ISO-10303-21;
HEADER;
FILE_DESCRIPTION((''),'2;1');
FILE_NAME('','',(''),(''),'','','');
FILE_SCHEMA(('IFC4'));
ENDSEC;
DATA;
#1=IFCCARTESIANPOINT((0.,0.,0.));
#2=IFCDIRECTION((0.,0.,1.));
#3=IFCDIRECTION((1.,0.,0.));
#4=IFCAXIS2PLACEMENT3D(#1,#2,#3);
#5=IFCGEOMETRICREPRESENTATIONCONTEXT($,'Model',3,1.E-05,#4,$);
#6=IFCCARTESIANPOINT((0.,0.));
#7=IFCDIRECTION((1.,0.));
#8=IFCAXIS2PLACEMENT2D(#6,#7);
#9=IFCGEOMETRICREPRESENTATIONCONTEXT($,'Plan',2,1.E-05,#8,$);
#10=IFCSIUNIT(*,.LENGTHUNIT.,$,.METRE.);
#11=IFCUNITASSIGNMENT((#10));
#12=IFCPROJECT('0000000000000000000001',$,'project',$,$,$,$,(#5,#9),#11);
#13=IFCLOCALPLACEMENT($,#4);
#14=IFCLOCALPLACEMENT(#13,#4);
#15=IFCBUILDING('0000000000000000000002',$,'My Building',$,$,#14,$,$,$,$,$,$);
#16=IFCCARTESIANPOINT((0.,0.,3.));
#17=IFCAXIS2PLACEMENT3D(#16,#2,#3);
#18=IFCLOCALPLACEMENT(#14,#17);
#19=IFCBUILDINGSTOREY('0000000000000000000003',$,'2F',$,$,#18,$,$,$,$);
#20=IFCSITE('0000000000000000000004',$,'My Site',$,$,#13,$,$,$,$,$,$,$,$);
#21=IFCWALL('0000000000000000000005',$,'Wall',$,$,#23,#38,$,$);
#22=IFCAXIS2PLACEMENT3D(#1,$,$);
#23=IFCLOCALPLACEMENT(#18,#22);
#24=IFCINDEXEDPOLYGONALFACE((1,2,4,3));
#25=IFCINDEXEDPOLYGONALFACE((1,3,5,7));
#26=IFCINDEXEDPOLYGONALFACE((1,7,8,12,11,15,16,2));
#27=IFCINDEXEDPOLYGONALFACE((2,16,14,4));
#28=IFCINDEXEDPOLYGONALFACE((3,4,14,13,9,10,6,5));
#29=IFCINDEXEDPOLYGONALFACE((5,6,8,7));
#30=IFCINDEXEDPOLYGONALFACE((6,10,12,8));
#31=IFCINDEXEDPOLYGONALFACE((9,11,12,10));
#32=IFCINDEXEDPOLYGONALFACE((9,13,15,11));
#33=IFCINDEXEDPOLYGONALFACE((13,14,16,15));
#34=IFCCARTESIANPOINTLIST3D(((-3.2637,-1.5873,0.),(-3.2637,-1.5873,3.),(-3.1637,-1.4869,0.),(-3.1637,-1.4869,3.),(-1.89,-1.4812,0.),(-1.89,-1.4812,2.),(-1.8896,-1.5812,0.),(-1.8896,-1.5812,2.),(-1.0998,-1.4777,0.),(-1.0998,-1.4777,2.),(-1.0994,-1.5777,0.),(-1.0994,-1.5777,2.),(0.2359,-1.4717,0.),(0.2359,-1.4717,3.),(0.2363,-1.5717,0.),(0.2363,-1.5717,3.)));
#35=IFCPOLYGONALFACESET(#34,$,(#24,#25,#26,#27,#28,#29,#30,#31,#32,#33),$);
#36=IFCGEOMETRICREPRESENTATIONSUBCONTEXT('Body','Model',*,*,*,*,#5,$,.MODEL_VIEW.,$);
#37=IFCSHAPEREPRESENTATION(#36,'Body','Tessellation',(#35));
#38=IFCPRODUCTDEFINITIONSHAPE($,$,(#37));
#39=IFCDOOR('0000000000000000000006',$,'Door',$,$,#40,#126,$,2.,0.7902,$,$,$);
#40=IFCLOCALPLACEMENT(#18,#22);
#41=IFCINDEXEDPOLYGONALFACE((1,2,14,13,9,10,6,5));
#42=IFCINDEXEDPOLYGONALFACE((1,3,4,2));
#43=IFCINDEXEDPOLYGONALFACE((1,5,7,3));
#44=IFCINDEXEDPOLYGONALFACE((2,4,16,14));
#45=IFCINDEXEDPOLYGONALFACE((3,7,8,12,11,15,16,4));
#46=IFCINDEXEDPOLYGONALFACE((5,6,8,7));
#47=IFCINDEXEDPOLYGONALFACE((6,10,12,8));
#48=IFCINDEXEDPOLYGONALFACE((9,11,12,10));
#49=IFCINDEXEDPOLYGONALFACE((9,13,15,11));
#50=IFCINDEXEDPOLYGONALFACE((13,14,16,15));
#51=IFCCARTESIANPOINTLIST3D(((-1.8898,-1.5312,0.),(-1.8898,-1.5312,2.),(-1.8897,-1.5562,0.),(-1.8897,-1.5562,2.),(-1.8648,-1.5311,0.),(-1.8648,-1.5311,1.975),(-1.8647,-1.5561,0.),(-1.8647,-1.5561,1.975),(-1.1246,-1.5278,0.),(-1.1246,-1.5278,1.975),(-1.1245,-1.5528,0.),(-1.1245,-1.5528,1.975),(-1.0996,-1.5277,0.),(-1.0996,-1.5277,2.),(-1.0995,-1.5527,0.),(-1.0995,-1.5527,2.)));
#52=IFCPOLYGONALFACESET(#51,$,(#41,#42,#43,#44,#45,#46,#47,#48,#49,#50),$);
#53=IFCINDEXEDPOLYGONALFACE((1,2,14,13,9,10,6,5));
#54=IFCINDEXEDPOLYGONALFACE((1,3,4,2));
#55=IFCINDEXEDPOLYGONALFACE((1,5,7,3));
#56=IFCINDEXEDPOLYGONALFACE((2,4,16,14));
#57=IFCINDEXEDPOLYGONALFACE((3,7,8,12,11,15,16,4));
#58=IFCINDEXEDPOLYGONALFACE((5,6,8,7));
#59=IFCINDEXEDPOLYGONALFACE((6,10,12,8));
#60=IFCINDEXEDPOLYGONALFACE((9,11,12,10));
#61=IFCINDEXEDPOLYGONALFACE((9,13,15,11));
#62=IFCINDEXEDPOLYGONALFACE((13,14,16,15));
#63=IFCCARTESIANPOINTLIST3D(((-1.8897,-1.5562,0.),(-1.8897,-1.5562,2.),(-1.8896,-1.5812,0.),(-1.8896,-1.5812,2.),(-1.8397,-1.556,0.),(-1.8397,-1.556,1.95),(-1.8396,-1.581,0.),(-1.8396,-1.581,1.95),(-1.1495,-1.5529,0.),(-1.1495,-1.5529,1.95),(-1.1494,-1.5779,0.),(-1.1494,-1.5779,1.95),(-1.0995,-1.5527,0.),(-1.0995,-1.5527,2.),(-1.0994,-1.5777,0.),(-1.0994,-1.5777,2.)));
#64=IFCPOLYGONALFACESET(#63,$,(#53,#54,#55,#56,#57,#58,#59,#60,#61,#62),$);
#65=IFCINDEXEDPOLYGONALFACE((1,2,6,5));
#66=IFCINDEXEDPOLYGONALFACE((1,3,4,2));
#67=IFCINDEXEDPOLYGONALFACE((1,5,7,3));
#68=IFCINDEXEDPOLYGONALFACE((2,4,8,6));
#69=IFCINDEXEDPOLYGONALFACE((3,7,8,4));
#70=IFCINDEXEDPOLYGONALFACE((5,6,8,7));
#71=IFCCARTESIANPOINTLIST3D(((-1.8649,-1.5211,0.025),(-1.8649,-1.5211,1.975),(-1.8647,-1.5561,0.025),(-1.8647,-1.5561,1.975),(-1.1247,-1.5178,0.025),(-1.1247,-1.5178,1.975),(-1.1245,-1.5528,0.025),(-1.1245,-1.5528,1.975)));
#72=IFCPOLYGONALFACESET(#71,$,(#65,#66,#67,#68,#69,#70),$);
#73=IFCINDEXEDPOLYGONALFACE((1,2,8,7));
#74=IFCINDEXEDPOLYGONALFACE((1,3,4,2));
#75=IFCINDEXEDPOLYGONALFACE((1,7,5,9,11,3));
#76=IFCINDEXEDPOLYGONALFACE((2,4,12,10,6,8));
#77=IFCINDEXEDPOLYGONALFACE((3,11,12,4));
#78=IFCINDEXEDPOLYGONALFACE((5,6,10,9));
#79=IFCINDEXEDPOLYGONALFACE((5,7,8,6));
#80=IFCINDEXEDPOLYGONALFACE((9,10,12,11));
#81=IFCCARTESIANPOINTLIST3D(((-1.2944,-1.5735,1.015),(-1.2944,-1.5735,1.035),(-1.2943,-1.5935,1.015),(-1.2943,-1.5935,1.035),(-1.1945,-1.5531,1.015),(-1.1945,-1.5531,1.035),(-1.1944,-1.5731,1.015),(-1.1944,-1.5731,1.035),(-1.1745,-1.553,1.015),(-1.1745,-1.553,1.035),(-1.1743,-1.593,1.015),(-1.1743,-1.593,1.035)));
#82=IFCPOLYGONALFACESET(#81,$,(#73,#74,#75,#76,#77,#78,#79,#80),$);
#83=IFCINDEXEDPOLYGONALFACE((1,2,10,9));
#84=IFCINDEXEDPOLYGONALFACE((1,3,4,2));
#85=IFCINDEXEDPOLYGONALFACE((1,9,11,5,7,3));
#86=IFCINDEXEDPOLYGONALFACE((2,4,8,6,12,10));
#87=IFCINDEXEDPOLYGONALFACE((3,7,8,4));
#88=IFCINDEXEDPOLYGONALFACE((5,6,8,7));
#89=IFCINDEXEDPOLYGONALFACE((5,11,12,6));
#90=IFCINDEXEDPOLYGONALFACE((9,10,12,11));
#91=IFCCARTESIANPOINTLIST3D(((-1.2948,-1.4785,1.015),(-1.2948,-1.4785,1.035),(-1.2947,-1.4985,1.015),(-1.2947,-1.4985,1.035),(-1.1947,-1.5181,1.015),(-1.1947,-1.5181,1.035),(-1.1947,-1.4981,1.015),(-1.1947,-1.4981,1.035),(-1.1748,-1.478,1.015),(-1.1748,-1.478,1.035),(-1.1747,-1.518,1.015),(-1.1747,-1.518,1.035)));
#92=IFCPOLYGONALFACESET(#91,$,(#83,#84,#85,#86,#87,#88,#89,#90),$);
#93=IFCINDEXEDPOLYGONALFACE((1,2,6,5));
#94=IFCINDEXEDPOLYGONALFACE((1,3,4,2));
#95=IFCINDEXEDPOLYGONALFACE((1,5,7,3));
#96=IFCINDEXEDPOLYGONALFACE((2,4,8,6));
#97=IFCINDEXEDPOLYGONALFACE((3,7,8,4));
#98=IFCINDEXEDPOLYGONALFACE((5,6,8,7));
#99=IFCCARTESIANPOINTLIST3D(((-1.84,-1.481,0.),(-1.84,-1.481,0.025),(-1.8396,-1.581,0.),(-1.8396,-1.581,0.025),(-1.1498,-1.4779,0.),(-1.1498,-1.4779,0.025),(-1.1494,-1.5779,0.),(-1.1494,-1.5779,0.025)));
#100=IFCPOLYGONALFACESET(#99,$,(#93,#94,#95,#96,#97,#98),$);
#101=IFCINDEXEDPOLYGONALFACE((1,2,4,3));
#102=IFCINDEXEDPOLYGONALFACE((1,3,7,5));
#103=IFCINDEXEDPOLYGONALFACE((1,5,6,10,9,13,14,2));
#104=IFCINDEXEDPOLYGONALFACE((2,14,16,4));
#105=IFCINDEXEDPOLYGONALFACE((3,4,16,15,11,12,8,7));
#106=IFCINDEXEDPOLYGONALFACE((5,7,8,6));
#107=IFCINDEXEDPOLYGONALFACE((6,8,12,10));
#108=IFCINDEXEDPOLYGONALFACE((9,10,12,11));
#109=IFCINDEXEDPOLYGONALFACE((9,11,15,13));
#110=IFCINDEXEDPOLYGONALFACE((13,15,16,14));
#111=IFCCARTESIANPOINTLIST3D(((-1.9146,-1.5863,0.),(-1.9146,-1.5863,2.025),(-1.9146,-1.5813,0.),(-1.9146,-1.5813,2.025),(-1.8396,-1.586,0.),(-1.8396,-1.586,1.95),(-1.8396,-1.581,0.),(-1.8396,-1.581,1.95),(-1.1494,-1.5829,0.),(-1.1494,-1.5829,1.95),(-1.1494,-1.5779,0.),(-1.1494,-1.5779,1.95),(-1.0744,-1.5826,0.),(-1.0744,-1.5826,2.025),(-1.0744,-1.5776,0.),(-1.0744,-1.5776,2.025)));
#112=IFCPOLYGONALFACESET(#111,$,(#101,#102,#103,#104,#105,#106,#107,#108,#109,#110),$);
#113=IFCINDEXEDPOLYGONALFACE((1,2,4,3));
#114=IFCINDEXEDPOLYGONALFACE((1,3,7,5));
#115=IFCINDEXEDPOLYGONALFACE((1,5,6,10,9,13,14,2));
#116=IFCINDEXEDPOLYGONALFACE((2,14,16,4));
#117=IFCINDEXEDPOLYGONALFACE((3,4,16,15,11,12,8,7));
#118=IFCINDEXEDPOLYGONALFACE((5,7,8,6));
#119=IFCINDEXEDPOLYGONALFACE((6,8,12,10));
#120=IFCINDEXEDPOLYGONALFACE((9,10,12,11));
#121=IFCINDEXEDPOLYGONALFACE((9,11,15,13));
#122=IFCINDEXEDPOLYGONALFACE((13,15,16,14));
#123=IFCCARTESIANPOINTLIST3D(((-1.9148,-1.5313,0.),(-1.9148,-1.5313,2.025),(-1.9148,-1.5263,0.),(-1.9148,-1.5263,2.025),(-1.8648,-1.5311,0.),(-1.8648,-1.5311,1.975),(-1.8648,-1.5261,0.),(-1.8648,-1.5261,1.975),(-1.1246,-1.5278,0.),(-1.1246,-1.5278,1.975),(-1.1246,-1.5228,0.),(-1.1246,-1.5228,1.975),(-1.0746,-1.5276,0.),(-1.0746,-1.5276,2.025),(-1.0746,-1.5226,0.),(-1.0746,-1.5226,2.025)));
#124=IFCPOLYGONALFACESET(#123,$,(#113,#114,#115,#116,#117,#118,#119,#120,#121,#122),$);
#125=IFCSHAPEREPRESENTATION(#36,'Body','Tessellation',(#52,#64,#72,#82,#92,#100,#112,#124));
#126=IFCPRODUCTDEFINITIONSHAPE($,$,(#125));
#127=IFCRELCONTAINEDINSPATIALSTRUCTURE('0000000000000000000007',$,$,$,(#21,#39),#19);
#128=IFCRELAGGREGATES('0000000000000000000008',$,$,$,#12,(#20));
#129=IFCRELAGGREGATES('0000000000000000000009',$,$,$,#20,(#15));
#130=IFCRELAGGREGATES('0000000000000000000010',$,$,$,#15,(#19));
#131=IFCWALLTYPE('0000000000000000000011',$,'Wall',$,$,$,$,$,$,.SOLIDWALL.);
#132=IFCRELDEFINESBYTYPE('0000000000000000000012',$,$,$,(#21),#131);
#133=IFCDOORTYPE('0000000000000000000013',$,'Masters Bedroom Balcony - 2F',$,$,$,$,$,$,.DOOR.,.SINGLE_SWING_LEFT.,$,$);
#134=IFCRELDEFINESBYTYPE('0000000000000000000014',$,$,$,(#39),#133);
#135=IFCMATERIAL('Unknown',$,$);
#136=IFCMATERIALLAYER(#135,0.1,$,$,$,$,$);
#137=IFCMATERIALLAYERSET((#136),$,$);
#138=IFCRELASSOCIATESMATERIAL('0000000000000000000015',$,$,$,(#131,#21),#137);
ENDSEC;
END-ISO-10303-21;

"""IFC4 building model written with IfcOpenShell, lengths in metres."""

from ifc_helpers import new_model, entity, si_unit, frame, origin_with_axes, origin_2d_with_axis, place, context, subcontext, project, spatial, line, indexed_curve, outline, extrude, shape, source, transform, mapped, material, layer, layer_set, layer_usage, type_object, type_shapes, element, fill, save


model = new_model("IFC4")

# Units and contexts
model_context = context("Model", 3, precision=1e-05, world=origin_with_axes())
plan_context = context("Plan", 2, precision=1e-05, world=origin_2d_with_axis())
body_context_1 = subcontext(model_context, "Body", "Model", "MODEL_VIEW")
body_context_2 = subcontext(plan_context, "Body", "Plan", "PLAN_VIEW")
ifc_project = project(units=[si_unit("LENGTHUNIT", "METRE")], contexts=[model_context, plan_context])

# Site, building, storey
site_placement = place(None, origin_with_axes())
site = spatial("IfcSite", under=ifc_project, at=site_placement, Name="My Site")
building_placement = place(site_placement, origin_with_axes())
building = spatial("IfcBuilding", under=site, at=building_placement, Name="My Building")
storey_placement = place(building_placement, frame((0.0, 0.0, 3.0), z_axis=(0.0, 0.0, 1.0), x_axis=(1.0, 0.0, 0.0)))
storey = spatial("IfcBuildingStorey", under=building, at=storey_placement, Name="2F")

# Shared definitions
ifc_material = material(Name="Unknown")

# Shared definitions
ifc_layer_1 = layer(ifc_material, 0.1)
ifc_layer_set_1 = layer_set([ifc_layer_1])
wall_type = type_object("IfcWallType", Name="Wall", PredefinedType="SOLIDWALL", material=ifc_layer_set_1)

# Wall, opening, door
ifc_layer_usage_1 = layer_usage(ifc_layer_set_1, "AXIS2", "POSITIVE", 0.0)
wall_1_placement = place(storey_placement, frame((-3.2637, -1.5873, 0.0), z_axis=(0.0, 0.0, 1.0), x_axis=(0.99999, 0.004461, 0.0)))
wall_1 = element("IfcWall", 1, at=wall_1_placement, inside=storey, type_object=wall_type, material=ifc_layer_usage_1, Name="Wall", context=body_context_1, shape_type="SweptSolid", body=[
    extrude(outline(indexed_curve([(0.0, 0.0), (0.1004, 0.1), (3.5, 0.1), (3.5, 0.0)], segments=[line(1, 2, 3, 4, 1)])), origin_with_axes(), (0.0, 0.0, 1.0), 3.0),
])
shared_shape_1 = source(origin_with_axes(), body_context_1, "Body", "SweptSolid", [
    extrude(outline(indexed_curve([(0.0, 0.0), (0.7902, 0.0), (0.7902, 2.0), (0.0, 2.0)], segments=[line(1, 2, 3, 4, 1)])), frame((0.0, -0.6, 0.0), z_axis=(0.0, -1.0, 0.0), x_axis=(1.0, 0.0, 0.0)), (0.0, 0.0, -1.0), 1.2),
])
opening_1_placement = place(wall_1_placement, frame((1.3741, 0.0, 0.0), z_axis=(0.0, 0.0, 1.0), x_axis=(1.0, 0.0, 0.0)))
opening_1 = element("IfcOpeningElement", 2, at=opening_1_placement, cuts=wall_1, PredefinedType="OPENING", context=body_context_1, shape_type="MappedRepresentation", body=[
    mapped(shared_shape_1, transform((0.0, 0.0, 0.0), x_axis=(1.0, 0.0, 0.0), y_axis=(0.0, 1.0, 0.0), z_axis=(0.0, 0.0, 1.0), scale=1.0)),
])
door_type_1 = type_object("IfcDoorType", Name="Masters Bedroom Balcony - 2F", OperationType="SINGLE_SWING_LEFT", PredefinedType="DOOR")
shared_shape_2 = source(origin_with_axes(), body_context_1, "Body", "SweptSolid", [
    extrude(outline(indexed_curve([(0.0, 0.0), (0.0, 2.0), (0.7902, 2.0), (0.7902, 0.0), (0.7652, 0.0), (0.7652, 1.975), (0.025, 1.975), (0.025, 0.0)], segments=[line(1, 2, 3, 4, 5, 6, 7, 8, 1)])), frame((0.0, 0.025, 0.0), z_axis=(0.0, -1.0, 0.0), x_axis=(1.0, 0.0, 0.0)), (0.0, 0.0, -1.0), 0.025),
    extrude(outline(indexed_curve([(0.0, 0.0), (0.0, 2.0), (0.7902, 2.0), (0.7902, 0.0), (0.7402, 0.0), (0.7402, 1.95), (0.05, 1.95), (0.05, 0.0)], segments=[line(1, 2, 3, 4, 5, 6, 7, 8, 1)])), frame((0.0, 0.0, 0.0), z_axis=(0.0, -1.0, 0.0), x_axis=(1.0, 0.0, 0.0)), (0.0, 0.0, -1.0), 0.025),
    extrude(outline(indexed_curve([(0.0, 0.0), (0.7402, 0.0), (0.7402, 0.035), (0.0, 0.035)], segments=[line(1, 2, 3, 4, 1)])), frame((0.025, 0.025, 0.025), z_axis=(0.0, 0.0, 1.0), x_axis=(1.0, 0.0, 0.0)), (0.0, 0.0, 1.0), 1.95),
    extrude(outline(indexed_curve([(0.0, 0.0), (0.0, -0.04), (-0.12, -0.04), (-0.12, -0.02), (-0.02, -0.02), (-0.02, 0.0)], segments=[line(1, 2, 3, 4, 5, 6, 1)])), frame((0.7152, 0.025, 1.015), z_axis=(0.0, 0.0, 1.0), x_axis=(1.0, 0.0, 0.0)), (0.0, 0.0, 1.0), 0.02),
    extrude(outline(indexed_curve([(0.0, 0.0), (0.0, 0.04), (-0.12, 0.04), (-0.12, 0.02), (-0.02, 0.02), (-0.02, 0.0)], segments=[line(1, 2, 3, 4, 5, 6, 1)])), frame((0.7152, 0.06, 1.015), z_axis=(0.0, 0.0, 1.0), x_axis=(1.0, 0.0, 0.0)), (0.0, 0.0, 1.0), 0.02),
    extrude(outline(indexed_curve([(0.0, 0.0), (0.6902, 0.0), (0.6902, 0.1), (0.0, 0.1)], segments=[line(1, 2, 3, 4, 1)])), frame((0.05, 0.0, 0.0), z_axis=(0.0, 0.0, 1.0), x_axis=(1.0, 0.0, 0.0)), (0.0, 0.0, 1.0), 0.025),
    extrude(outline(indexed_curve([(0.0, 0.0), (0.0, 2.025), (0.8402, 2.025), (0.8402, 0.0), (0.7652, 0.0), (0.7652, 1.95), (0.075, 1.95), (0.075, 0.0)], segments=[line(1, 2, 3, 4, 5, 6, 7, 8, 1)])), frame((-0.025, -0.005, 0.0), z_axis=(0.0, -1.0, 0.0), x_axis=(1.0, 0.0, 0.0)), (0.0, 0.0, -1.0), 0.005),
    extrude(outline(indexed_curve([(0.0, 0.0), (0.0, 2.025), (0.8402, 2.025), (0.8402, 0.0), (0.7902, 0.0), (0.7902, 1.975), (0.05, 1.975), (0.05, 0.0)], segments=[line(1, 2, 3, 4, 5, 6, 7, 8, 1)])), frame((-0.025, 0.05, 0.0), z_axis=(0.0, -1.0, 0.0), x_axis=(1.0, 0.0, 0.0)), (0.0, 0.0, -1.0), 0.005),
])
shared_shape_3 = source(origin_with_axes(), body_context_2, "Body", "Curve2D", [
    entity("IfcIndexedPolyCurve", entity("IfcCartesianPointList2D", [[0.0, 0.0], [0.0, 0.05], [0.025, 0.05], [0.025, 0.025], [0.05, 0.025], [0.05, 0.0]]), [entity("IfcLineIndex", [1, 2, 3, 4, 5, 6, 1])]),
    entity("IfcIndexedPolyCurve", entity("IfcCartesianPointList2D", [[0.7902, 0.0], [0.7902, 0.05], [0.7652, 0.05], [0.7652, 0.025], [0.7402, 0.025], [0.7402, 0.0]]), [entity("IfcLineIndex", [1, 2, 3, 4, 5, 6, 1])]),
    entity("IfcTrimmedCurve", entity("IfcEllipse", entity("IfcAxis2Placement2D", entity("IfcCartesianPoint", [0.06, 0.05]), entity("IfcDirection", [1.0, 0.0])), 0.7052, 0.7402), [entity("IfcCartesianPoint", [0.7652, 0.05])], [entity("IfcCartesianPoint", [0.06, 0.7902])], True, "CARTESIAN"),
    entity("IfcIndexedPolyCurve", entity("IfcCartesianPointList2D", [[0.025, 0.05], [0.06, 0.05], [0.06, 0.7902], [0.025, 0.7902]]), [entity("IfcLineIndex", [1, 2, 3, 4, 1])]),
])
type_shapes(door_type_1, [shared_shape_2, shared_shape_3])
door_1_placement = place(opening_1_placement, frame((0.0, 0.0, 0.0), z_axis=(0.0, 0.0, 1.0), x_axis=(1.0, 0.0, 0.0)))
door_1 = element("IfcDoor", 3, at=door_1_placement, inside=storey, type_object=door_type_1, Name="Door", OverallHeight=2.0, OverallWidth=0.7902, shapes=[
    shape(body_context_1, "Body", "MappedRepresentation", [mapped(shared_shape_2, transform((0.0, 0.0, 0.0), x_axis=(1.0, 0.0, 0.0), y_axis=(0.0, 1.0, 0.0), z_axis=(0.0, 0.0, 1.0), scale=1.0))]),
    shape(body_context_2, "Body", "MappedRepresentation", [mapped(shared_shape_3, transform((0.0, 0.0, 0.0), x_axis=(1.0, 0.0, 0.0), y_axis=(0.0, 1.0, 0.0), z_axis=(0.0, 0.0, 1.0), scale=1.0))]),
])
fill(opening_1, door_1)

save(model, "model.ifc")
